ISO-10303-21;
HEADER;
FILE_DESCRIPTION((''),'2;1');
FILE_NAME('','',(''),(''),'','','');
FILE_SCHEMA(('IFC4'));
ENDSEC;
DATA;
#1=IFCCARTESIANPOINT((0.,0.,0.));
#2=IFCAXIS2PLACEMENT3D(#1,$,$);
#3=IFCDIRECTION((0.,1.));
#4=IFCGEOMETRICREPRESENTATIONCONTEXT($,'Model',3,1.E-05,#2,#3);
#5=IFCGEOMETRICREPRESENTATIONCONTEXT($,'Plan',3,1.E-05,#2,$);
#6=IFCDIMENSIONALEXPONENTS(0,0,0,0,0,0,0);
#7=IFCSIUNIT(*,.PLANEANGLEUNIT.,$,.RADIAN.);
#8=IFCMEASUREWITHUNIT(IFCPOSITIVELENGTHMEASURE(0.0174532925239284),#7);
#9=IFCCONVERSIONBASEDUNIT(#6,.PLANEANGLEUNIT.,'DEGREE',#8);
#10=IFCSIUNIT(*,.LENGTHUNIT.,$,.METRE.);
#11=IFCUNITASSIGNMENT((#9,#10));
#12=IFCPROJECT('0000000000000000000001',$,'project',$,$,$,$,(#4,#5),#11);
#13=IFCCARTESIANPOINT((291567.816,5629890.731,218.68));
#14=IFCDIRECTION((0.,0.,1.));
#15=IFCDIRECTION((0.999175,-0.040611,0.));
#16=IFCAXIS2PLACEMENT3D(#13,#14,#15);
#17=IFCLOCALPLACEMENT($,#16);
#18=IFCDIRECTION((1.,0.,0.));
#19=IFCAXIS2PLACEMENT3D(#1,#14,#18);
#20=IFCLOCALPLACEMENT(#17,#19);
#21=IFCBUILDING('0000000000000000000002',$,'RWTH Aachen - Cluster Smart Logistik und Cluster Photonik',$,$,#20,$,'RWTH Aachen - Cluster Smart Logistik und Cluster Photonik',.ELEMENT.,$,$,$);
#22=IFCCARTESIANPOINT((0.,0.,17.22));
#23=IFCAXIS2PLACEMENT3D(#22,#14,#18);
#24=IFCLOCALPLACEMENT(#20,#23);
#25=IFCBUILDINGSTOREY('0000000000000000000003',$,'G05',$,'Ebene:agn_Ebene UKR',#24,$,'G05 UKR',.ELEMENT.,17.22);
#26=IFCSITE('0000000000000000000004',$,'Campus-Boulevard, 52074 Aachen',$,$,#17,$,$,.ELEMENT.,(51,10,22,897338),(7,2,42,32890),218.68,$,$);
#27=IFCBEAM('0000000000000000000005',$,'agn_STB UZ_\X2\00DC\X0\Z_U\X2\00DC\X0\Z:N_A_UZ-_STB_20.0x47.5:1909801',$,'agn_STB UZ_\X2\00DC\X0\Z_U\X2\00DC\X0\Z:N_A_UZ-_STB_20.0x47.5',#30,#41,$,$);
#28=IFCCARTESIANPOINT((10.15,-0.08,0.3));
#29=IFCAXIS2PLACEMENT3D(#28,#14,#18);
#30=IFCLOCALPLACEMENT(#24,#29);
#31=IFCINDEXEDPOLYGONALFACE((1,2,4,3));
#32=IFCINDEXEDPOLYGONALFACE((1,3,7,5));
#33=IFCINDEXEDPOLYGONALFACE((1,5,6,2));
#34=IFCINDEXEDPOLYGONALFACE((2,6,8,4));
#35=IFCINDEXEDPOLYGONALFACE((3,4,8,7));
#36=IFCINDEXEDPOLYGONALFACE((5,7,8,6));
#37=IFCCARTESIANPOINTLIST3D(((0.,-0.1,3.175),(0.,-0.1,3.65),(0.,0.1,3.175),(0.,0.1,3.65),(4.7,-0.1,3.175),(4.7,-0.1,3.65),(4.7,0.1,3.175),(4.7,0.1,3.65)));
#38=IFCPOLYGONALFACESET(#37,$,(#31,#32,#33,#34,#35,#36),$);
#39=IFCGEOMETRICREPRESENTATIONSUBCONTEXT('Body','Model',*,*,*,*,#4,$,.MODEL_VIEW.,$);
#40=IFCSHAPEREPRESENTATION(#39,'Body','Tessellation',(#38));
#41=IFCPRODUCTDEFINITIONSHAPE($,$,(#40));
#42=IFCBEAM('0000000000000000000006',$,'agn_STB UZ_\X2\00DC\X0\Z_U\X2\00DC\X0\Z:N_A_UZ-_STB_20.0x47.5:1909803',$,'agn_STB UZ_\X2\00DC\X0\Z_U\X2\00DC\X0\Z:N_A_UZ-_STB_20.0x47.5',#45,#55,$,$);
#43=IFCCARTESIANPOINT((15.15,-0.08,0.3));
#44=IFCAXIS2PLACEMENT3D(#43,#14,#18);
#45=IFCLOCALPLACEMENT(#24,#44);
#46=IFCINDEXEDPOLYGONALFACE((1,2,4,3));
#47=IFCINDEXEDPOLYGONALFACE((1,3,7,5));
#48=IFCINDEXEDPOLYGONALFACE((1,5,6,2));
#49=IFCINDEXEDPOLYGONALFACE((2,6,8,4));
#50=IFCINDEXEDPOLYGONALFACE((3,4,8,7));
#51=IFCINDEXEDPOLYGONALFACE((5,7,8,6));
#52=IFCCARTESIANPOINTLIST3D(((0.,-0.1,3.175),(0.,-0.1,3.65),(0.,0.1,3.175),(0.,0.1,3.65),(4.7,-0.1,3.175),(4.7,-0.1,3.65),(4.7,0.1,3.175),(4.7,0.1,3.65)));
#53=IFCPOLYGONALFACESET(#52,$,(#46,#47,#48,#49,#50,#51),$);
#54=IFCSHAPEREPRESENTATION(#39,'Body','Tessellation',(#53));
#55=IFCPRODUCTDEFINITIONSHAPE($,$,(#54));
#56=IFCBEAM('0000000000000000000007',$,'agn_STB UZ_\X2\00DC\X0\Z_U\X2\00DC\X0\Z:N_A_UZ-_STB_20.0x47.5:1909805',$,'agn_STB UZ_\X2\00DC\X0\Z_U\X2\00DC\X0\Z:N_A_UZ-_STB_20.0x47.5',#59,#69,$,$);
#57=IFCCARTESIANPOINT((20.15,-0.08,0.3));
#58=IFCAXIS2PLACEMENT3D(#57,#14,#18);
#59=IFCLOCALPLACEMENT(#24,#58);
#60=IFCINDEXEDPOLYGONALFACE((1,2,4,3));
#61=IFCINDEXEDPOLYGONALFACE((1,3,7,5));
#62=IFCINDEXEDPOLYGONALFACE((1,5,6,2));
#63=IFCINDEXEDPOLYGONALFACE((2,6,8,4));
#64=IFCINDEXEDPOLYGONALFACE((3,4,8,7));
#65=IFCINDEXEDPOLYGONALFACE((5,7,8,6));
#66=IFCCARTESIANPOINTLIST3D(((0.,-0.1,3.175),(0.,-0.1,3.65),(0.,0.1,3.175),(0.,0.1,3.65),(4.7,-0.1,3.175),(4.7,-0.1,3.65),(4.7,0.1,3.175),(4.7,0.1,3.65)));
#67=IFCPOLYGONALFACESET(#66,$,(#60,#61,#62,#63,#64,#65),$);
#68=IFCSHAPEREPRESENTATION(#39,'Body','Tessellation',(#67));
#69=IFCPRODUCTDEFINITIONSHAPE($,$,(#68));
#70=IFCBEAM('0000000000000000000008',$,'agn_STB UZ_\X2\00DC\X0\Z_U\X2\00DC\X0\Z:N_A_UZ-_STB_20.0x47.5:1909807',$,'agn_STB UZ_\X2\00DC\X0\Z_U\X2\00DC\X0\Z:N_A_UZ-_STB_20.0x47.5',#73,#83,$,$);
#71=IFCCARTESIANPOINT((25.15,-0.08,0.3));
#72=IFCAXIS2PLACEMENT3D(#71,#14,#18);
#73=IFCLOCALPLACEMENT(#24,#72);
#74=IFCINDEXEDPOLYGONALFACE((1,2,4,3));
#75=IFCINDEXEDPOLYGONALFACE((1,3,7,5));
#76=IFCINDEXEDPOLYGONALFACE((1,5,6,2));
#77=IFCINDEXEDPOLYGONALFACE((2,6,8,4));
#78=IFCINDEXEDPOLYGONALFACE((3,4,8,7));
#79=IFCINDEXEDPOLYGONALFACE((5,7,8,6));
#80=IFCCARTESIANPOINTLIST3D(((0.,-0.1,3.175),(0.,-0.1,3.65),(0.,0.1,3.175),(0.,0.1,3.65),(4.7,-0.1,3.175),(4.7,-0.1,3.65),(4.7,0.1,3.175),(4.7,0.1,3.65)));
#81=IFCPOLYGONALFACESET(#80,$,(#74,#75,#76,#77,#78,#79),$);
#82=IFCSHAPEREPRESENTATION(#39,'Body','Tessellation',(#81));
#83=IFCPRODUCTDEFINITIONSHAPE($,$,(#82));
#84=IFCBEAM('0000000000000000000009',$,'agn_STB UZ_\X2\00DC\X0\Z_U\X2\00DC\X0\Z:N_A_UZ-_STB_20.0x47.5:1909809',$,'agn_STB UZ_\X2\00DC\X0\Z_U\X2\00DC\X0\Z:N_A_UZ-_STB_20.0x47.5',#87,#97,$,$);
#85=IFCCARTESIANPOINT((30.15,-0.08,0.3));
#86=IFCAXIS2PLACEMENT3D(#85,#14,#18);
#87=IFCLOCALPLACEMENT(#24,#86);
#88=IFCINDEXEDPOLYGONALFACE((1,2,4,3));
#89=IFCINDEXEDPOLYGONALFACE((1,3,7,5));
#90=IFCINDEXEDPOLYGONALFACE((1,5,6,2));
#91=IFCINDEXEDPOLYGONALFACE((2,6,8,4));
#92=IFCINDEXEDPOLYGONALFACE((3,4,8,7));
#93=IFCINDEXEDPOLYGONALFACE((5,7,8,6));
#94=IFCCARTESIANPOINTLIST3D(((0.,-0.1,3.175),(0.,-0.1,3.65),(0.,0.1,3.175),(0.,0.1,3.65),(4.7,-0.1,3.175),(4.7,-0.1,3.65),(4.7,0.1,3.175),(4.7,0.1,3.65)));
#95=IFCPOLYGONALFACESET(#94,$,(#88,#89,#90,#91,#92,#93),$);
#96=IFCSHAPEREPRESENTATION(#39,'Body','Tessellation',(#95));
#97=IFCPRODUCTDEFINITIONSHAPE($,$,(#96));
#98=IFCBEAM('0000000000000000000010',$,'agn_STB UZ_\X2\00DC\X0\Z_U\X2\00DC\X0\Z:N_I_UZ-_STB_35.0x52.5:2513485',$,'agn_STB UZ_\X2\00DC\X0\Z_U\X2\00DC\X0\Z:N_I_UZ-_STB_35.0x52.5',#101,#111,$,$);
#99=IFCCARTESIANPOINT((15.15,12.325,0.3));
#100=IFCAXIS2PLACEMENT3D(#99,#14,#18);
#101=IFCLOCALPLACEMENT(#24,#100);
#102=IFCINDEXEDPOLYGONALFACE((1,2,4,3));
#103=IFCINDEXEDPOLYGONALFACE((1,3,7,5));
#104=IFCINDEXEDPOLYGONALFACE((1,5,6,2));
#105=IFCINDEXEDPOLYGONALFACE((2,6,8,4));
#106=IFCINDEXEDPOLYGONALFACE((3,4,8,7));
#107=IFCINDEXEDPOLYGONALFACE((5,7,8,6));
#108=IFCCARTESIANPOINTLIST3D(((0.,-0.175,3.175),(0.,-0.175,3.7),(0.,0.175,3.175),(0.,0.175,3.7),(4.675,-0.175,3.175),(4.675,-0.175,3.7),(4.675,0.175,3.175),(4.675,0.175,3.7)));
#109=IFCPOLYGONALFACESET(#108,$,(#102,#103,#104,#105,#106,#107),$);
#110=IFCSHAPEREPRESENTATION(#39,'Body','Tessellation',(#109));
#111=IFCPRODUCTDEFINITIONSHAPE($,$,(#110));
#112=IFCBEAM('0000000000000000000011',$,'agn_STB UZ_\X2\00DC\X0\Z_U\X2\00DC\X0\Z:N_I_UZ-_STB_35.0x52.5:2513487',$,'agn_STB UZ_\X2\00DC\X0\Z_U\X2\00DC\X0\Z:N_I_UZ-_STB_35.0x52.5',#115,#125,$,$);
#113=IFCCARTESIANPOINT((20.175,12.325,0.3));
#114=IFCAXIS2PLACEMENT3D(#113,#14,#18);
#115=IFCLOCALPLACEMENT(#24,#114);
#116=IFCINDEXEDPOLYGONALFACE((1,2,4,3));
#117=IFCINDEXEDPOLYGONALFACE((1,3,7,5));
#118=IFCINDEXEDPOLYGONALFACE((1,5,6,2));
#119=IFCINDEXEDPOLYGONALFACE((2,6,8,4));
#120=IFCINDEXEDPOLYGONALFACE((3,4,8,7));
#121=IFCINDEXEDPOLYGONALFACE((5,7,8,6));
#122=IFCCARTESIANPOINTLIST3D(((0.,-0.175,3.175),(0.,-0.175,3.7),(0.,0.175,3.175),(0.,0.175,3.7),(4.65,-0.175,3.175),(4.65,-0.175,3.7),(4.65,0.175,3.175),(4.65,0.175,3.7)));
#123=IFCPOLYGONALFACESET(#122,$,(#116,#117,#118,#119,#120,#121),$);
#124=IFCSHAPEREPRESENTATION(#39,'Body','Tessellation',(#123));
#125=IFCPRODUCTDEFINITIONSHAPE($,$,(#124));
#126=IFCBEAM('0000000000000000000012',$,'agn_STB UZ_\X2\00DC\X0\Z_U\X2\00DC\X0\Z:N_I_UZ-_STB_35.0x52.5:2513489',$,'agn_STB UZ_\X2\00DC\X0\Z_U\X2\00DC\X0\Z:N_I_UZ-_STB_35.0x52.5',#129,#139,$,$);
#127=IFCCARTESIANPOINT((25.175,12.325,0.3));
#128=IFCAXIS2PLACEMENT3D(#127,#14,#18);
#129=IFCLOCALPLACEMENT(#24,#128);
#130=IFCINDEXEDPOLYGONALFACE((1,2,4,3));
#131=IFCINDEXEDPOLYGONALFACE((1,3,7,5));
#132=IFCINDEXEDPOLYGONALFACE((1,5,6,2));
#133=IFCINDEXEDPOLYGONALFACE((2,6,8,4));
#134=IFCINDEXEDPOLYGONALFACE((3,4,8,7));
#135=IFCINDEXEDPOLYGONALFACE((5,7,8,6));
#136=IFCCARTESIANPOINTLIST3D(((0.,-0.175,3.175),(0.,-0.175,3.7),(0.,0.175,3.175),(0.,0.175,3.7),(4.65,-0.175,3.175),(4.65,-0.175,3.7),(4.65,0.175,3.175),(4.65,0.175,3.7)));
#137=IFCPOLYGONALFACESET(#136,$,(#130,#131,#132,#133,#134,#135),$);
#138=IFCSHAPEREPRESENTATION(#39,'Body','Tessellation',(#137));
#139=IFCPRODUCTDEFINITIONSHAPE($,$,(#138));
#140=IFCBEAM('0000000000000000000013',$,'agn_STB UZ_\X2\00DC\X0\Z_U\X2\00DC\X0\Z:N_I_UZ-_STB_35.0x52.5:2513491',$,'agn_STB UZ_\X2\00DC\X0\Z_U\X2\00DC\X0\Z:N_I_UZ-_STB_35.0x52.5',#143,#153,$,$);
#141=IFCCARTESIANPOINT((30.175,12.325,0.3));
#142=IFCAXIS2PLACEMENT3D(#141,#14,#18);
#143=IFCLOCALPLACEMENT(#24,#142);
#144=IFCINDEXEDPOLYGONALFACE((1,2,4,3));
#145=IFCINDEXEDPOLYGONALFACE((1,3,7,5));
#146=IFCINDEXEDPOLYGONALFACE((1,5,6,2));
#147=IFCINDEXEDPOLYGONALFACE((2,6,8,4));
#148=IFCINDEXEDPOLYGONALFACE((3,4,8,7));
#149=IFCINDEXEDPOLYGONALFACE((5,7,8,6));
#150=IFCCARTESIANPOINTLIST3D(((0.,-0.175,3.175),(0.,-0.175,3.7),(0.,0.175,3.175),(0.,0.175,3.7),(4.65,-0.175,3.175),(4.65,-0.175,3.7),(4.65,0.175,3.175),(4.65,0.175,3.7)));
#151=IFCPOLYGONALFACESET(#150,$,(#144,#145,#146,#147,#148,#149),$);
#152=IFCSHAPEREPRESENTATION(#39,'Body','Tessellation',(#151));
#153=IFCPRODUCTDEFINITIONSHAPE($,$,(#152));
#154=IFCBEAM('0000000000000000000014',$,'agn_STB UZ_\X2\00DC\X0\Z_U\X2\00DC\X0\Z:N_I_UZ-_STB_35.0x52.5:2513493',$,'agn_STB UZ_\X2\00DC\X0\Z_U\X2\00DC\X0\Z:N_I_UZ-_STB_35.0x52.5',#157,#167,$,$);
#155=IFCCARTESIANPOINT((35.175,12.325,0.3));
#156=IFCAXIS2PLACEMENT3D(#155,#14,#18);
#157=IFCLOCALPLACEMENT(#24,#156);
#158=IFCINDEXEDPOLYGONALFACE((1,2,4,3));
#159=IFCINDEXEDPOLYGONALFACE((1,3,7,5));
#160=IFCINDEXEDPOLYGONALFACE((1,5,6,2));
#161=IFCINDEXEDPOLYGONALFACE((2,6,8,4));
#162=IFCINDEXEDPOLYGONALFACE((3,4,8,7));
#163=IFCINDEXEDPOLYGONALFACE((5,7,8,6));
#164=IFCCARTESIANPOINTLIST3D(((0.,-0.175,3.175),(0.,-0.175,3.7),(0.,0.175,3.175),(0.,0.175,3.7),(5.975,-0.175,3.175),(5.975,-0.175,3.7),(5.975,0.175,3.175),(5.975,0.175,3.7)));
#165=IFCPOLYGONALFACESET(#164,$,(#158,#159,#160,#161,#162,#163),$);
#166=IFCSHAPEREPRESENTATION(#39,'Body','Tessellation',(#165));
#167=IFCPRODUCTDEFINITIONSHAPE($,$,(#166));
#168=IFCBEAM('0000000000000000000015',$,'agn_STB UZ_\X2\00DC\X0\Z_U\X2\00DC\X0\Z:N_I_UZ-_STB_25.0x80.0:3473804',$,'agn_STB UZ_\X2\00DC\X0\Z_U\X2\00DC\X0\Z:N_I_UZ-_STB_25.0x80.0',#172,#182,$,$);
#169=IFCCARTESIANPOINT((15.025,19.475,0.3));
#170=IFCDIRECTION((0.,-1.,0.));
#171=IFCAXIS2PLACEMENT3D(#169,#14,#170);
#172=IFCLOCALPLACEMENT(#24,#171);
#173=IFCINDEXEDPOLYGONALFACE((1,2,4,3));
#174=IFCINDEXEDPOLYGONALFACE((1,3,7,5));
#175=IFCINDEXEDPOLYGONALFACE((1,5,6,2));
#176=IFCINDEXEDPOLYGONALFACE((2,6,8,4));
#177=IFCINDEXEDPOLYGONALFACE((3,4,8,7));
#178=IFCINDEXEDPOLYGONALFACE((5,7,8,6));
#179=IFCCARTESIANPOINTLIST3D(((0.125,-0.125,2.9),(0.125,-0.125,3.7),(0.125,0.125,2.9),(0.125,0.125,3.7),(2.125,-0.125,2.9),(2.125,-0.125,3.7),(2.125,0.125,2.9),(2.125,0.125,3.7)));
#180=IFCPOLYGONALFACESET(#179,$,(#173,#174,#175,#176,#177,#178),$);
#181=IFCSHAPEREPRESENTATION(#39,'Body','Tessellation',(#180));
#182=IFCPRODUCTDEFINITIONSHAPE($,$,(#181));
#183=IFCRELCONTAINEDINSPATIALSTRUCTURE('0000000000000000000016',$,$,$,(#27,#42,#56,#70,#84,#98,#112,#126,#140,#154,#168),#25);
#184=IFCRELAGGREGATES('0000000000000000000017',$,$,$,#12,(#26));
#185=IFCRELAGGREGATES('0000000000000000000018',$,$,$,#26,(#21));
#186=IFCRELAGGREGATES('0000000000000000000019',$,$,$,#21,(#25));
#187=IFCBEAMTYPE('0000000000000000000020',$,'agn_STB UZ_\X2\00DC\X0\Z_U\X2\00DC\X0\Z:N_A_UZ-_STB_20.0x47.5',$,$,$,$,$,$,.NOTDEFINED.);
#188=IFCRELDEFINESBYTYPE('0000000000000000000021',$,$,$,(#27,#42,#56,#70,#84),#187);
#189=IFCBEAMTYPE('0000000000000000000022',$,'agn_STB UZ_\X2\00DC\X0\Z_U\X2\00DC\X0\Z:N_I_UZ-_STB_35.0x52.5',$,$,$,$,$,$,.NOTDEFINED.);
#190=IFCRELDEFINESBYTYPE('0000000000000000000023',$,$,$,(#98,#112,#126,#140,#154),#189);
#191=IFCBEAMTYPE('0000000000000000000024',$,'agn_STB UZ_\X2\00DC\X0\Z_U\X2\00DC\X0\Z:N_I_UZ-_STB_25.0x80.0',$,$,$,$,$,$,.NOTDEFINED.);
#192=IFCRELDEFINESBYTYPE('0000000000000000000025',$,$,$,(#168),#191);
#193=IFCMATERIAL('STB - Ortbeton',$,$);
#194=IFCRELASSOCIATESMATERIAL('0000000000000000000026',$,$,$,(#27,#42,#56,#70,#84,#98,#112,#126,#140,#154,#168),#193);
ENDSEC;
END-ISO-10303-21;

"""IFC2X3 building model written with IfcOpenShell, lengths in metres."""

from ifc_helpers import new_model, entity, si_unit, converted_unit, direction, frame, frame_2d, origin, origin_with_axes, origin_2d_with_axis, place, context, subcontext, project, spatial, rectangle, extrude, material, type_object, element, save


model = new_model("IFC2X3")

# Units and contexts
model_context = context("Model", 3, precision=1e-05, world=origin(), true_north=direction((0.0, 1.0)))
plan_context = context("Plan", 3, precision=1e-05, world=origin())
body_context = subcontext(model_context, "Body", "Model", "MODEL_VIEW")
ifc_project = project(units=[converted_unit("PLANEANGLEUNIT", "DEGREE", entity("IfcPositiveLengthMeasure", 0.0174532925239284), si_unit("PLANEANGLEUNIT", "RADIAN"), dimensions=[0, 0, 0, 0, 0, 0, 0]), si_unit("LENGTHUNIT", "METRE")], contexts=[model_context, plan_context])

# Site, building, storey
site_placement = place(None, frame((291567.816, 5629890.731, 218.68), z_axis=(0.0, 0.0, 1.0), x_axis=(0.999175, -0.040611, 0.0)))
site = spatial("IfcSite", under=ifc_project, at=site_placement, Name="Campus-Boulevard, 52074 Aachen", CompositionType="ELEMENT", RefLatitude=(51, 10, 22, 897338), RefLongitude=(7, 2, 42, 32890), RefElevation=218.68)
building_placement = place(site_placement, origin_with_axes())
building = spatial("IfcBuilding", under=site, at=building_placement, Name="RWTH Aachen - Cluster Smart Logistik und Cluster Photonik", LongName="RWTH Aachen - Cluster Smart Logistik und Cluster Photonik", CompositionType="ELEMENT")
storey_placement = place(building_placement, frame((0.0, 0.0, 17.22), z_axis=(0.0, 0.0, 1.0), x_axis=(1.0, 0.0, 0.0)))
storey = spatial("IfcBuildingStorey", under=building, at=storey_placement, Name="G05", ObjectType="Ebene:agn_Ebene UKR", LongName="G05 UKR", CompositionType="ELEMENT", Elevation=17.22)

# Beams
ifc_material_1 = material(Name="STB - Ortbeton")
beam_type_1 = type_object("IfcBeamType", Name="agn_STB UZ_ÜZ_UÜZ:N_A_UZ-_STB_20.0x47.5", PredefinedType="NOTDEFINED")
for number, where, z_axis, x_axis, name in (
    (1, (10.15, -0.08, 0.3), (0.0, 0.0, 1.0), (1.0, 0.0, 0.0), "agn_STB UZ_ÜZ_UÜZ:N_A_UZ-_STB_20.0x47.5:1909801"),
    (2, (15.15, -0.08, 0.3), (0.0, 0.0, 1.0), (1.0, 0.0, 0.0), "agn_STB UZ_ÜZ_UÜZ:N_A_UZ-_STB_20.0x47.5:1909803"),
    (3, (20.15, -0.08, 0.3), (0.0, 0.0, 1.0), (1.0, 0.0, 0.0), "agn_STB UZ_ÜZ_UÜZ:N_A_UZ-_STB_20.0x47.5:1909805"),
    (4, (25.15, -0.08, 0.3), (0.0, 0.0, 1.0), (1.0, 0.0, 0.0), "agn_STB UZ_ÜZ_UÜZ:N_A_UZ-_STB_20.0x47.5:1909807"),
    (5, (30.15, -0.08, 0.3), (0.0, 0.0, 1.0), (1.0, 0.0, 0.0), "agn_STB UZ_ÜZ_UÜZ:N_A_UZ-_STB_20.0x47.5:1909809"),
):
    element("IfcBeam", number, at=place(storey_placement, frame(where, z_axis=z_axis, x_axis=x_axis)), inside=storey, type_object=beam_type_1, material=ifc_material_1, Name=name, ObjectType="agn_STB UZ_ÜZ_UÜZ:N_A_UZ-_STB_20.0x47.5", context=body_context, shape_type="SweptSolid", body=[
        extrude(rectangle(XDim=0.475, YDim=0.2, at=frame_2d((0.0, 0.0), x_axis=(1.0, 0.0))), frame((0.0, 0.0, 3.4125), z_axis=(1.0, 0.0, 0.0), x_axis=(0.0, 0.0, -1.0)), (0.0, 0.0, 1.0), 4.7),
    ])
beam_type_2 = type_object("IfcBeamType", Name="agn_STB UZ_ÜZ_UÜZ:N_I_UZ-_STB_35.0x52.5", PredefinedType="NOTDEFINED")
beam_1_placement = place(storey_placement, frame((15.15, 12.325, 0.3), z_axis=(0.0, 0.0, 1.0), x_axis=(1.0, 0.0, 0.0)))
element("IfcBeam", 6, at=beam_1_placement, inside=storey, type_object=beam_type_2, material=ifc_material_1, Name="agn_STB UZ_ÜZ_UÜZ:N_I_UZ-_STB_35.0x52.5:2513485", ObjectType="agn_STB UZ_ÜZ_UÜZ:N_I_UZ-_STB_35.0x52.5", context=body_context, shape_type="SweptSolid", body=[
    extrude(rectangle(XDim=0.525, YDim=0.35, at=frame_2d((0.0, 0.0), x_axis=(1.0, 0.0))), frame((0.0, 0.0, 3.4375), z_axis=(1.0, 0.0, 0.0), x_axis=(0.0, 0.0, -1.0)), (0.0, 0.0, 1.0), 4.675),
])
for number, where, z_axis, x_axis, name in (
    (7, (20.175, 12.325, 0.3), (0.0, 0.0, 1.0), (1.0, 0.0, 0.0), "agn_STB UZ_ÜZ_UÜZ:N_I_UZ-_STB_35.0x52.5:2513487"),
    (8, (25.175, 12.325, 0.3), (0.0, 0.0, 1.0), (1.0, 0.0, 0.0), "agn_STB UZ_ÜZ_UÜZ:N_I_UZ-_STB_35.0x52.5:2513489"),
    (9, (30.175, 12.325, 0.3), (0.0, 0.0, 1.0), (1.0, 0.0, 0.0), "agn_STB UZ_ÜZ_UÜZ:N_I_UZ-_STB_35.0x52.5:2513491"),
):
    element("IfcBeam", number, at=place(storey_placement, frame(where, z_axis=z_axis, x_axis=x_axis)), inside=storey, type_object=beam_type_2, material=ifc_material_1, Name=name, ObjectType="agn_STB UZ_ÜZ_UÜZ:N_I_UZ-_STB_35.0x52.5", context=body_context, shape_type="SweptSolid", body=[
        extrude(rectangle(XDim=0.525, YDim=0.35, at=frame_2d((0.0, 0.0), x_axis=(1.0, 0.0))), frame((0.0, 0.0, 3.4375), z_axis=(1.0, 0.0, 0.0), x_axis=(0.0, 0.0, -1.0)), (0.0, 0.0, 1.0), 4.65),
    ])
beam_2_placement = place(storey_placement, frame((35.175, 12.325, 0.3), z_axis=(0.0, 0.0, 1.0), x_axis=(1.0, 0.0, 0.0)))
element("IfcBeam", 10, at=beam_2_placement, inside=storey, type_object=beam_type_2, material=ifc_material_1, Name="agn_STB UZ_ÜZ_UÜZ:N_I_UZ-_STB_35.0x52.5:2513493", ObjectType="agn_STB UZ_ÜZ_UÜZ:N_I_UZ-_STB_35.0x52.5", context=body_context, shape_type="SweptSolid", body=[
    extrude(rectangle(XDim=0.525, YDim=0.35, at=frame_2d((0.0, 0.0), x_axis=(1.0, 0.0))), frame((0.0, 0.0, 3.4375), z_axis=(1.0, 0.0, 0.0), x_axis=(0.0, 0.0, -1.0)), (0.0, 0.0, 1.0), 5.975),
])
beam_type_3 = type_object("IfcBeamType", Name="agn_STB UZ_ÜZ_UÜZ:N_I_UZ-_STB_25.0x80.0", PredefinedType="NOTDEFINED")
beam_3_placement = place(storey_placement, frame((15.025, 19.475, 0.3), z_axis=(0.0, 0.0, 1.0), x_axis=(0.0, -1.0, 0.0)))
element("IfcBeam", 11, at=beam_3_placement, inside=storey, type_object=beam_type_3, material=ifc_material_1, Name="agn_STB UZ_ÜZ_UÜZ:N_I_UZ-_STB_25.0x80.0:3473804", ObjectType="agn_STB UZ_ÜZ_UÜZ:N_I_UZ-_STB_25.0x80.0", context=body_context, shape_type="SweptSolid", body=[
    extrude(rectangle(XDim=0.8, YDim=0.25, at=origin_2d_with_axis()), frame((0.125, 0.0, 3.3), z_axis=(1.0, 0.0, 0.0), x_axis=(0.0, 0.0, -1.0)), (0.0, 0.0, 1.0), 2.0),
])

save(model, "model.ifc")
